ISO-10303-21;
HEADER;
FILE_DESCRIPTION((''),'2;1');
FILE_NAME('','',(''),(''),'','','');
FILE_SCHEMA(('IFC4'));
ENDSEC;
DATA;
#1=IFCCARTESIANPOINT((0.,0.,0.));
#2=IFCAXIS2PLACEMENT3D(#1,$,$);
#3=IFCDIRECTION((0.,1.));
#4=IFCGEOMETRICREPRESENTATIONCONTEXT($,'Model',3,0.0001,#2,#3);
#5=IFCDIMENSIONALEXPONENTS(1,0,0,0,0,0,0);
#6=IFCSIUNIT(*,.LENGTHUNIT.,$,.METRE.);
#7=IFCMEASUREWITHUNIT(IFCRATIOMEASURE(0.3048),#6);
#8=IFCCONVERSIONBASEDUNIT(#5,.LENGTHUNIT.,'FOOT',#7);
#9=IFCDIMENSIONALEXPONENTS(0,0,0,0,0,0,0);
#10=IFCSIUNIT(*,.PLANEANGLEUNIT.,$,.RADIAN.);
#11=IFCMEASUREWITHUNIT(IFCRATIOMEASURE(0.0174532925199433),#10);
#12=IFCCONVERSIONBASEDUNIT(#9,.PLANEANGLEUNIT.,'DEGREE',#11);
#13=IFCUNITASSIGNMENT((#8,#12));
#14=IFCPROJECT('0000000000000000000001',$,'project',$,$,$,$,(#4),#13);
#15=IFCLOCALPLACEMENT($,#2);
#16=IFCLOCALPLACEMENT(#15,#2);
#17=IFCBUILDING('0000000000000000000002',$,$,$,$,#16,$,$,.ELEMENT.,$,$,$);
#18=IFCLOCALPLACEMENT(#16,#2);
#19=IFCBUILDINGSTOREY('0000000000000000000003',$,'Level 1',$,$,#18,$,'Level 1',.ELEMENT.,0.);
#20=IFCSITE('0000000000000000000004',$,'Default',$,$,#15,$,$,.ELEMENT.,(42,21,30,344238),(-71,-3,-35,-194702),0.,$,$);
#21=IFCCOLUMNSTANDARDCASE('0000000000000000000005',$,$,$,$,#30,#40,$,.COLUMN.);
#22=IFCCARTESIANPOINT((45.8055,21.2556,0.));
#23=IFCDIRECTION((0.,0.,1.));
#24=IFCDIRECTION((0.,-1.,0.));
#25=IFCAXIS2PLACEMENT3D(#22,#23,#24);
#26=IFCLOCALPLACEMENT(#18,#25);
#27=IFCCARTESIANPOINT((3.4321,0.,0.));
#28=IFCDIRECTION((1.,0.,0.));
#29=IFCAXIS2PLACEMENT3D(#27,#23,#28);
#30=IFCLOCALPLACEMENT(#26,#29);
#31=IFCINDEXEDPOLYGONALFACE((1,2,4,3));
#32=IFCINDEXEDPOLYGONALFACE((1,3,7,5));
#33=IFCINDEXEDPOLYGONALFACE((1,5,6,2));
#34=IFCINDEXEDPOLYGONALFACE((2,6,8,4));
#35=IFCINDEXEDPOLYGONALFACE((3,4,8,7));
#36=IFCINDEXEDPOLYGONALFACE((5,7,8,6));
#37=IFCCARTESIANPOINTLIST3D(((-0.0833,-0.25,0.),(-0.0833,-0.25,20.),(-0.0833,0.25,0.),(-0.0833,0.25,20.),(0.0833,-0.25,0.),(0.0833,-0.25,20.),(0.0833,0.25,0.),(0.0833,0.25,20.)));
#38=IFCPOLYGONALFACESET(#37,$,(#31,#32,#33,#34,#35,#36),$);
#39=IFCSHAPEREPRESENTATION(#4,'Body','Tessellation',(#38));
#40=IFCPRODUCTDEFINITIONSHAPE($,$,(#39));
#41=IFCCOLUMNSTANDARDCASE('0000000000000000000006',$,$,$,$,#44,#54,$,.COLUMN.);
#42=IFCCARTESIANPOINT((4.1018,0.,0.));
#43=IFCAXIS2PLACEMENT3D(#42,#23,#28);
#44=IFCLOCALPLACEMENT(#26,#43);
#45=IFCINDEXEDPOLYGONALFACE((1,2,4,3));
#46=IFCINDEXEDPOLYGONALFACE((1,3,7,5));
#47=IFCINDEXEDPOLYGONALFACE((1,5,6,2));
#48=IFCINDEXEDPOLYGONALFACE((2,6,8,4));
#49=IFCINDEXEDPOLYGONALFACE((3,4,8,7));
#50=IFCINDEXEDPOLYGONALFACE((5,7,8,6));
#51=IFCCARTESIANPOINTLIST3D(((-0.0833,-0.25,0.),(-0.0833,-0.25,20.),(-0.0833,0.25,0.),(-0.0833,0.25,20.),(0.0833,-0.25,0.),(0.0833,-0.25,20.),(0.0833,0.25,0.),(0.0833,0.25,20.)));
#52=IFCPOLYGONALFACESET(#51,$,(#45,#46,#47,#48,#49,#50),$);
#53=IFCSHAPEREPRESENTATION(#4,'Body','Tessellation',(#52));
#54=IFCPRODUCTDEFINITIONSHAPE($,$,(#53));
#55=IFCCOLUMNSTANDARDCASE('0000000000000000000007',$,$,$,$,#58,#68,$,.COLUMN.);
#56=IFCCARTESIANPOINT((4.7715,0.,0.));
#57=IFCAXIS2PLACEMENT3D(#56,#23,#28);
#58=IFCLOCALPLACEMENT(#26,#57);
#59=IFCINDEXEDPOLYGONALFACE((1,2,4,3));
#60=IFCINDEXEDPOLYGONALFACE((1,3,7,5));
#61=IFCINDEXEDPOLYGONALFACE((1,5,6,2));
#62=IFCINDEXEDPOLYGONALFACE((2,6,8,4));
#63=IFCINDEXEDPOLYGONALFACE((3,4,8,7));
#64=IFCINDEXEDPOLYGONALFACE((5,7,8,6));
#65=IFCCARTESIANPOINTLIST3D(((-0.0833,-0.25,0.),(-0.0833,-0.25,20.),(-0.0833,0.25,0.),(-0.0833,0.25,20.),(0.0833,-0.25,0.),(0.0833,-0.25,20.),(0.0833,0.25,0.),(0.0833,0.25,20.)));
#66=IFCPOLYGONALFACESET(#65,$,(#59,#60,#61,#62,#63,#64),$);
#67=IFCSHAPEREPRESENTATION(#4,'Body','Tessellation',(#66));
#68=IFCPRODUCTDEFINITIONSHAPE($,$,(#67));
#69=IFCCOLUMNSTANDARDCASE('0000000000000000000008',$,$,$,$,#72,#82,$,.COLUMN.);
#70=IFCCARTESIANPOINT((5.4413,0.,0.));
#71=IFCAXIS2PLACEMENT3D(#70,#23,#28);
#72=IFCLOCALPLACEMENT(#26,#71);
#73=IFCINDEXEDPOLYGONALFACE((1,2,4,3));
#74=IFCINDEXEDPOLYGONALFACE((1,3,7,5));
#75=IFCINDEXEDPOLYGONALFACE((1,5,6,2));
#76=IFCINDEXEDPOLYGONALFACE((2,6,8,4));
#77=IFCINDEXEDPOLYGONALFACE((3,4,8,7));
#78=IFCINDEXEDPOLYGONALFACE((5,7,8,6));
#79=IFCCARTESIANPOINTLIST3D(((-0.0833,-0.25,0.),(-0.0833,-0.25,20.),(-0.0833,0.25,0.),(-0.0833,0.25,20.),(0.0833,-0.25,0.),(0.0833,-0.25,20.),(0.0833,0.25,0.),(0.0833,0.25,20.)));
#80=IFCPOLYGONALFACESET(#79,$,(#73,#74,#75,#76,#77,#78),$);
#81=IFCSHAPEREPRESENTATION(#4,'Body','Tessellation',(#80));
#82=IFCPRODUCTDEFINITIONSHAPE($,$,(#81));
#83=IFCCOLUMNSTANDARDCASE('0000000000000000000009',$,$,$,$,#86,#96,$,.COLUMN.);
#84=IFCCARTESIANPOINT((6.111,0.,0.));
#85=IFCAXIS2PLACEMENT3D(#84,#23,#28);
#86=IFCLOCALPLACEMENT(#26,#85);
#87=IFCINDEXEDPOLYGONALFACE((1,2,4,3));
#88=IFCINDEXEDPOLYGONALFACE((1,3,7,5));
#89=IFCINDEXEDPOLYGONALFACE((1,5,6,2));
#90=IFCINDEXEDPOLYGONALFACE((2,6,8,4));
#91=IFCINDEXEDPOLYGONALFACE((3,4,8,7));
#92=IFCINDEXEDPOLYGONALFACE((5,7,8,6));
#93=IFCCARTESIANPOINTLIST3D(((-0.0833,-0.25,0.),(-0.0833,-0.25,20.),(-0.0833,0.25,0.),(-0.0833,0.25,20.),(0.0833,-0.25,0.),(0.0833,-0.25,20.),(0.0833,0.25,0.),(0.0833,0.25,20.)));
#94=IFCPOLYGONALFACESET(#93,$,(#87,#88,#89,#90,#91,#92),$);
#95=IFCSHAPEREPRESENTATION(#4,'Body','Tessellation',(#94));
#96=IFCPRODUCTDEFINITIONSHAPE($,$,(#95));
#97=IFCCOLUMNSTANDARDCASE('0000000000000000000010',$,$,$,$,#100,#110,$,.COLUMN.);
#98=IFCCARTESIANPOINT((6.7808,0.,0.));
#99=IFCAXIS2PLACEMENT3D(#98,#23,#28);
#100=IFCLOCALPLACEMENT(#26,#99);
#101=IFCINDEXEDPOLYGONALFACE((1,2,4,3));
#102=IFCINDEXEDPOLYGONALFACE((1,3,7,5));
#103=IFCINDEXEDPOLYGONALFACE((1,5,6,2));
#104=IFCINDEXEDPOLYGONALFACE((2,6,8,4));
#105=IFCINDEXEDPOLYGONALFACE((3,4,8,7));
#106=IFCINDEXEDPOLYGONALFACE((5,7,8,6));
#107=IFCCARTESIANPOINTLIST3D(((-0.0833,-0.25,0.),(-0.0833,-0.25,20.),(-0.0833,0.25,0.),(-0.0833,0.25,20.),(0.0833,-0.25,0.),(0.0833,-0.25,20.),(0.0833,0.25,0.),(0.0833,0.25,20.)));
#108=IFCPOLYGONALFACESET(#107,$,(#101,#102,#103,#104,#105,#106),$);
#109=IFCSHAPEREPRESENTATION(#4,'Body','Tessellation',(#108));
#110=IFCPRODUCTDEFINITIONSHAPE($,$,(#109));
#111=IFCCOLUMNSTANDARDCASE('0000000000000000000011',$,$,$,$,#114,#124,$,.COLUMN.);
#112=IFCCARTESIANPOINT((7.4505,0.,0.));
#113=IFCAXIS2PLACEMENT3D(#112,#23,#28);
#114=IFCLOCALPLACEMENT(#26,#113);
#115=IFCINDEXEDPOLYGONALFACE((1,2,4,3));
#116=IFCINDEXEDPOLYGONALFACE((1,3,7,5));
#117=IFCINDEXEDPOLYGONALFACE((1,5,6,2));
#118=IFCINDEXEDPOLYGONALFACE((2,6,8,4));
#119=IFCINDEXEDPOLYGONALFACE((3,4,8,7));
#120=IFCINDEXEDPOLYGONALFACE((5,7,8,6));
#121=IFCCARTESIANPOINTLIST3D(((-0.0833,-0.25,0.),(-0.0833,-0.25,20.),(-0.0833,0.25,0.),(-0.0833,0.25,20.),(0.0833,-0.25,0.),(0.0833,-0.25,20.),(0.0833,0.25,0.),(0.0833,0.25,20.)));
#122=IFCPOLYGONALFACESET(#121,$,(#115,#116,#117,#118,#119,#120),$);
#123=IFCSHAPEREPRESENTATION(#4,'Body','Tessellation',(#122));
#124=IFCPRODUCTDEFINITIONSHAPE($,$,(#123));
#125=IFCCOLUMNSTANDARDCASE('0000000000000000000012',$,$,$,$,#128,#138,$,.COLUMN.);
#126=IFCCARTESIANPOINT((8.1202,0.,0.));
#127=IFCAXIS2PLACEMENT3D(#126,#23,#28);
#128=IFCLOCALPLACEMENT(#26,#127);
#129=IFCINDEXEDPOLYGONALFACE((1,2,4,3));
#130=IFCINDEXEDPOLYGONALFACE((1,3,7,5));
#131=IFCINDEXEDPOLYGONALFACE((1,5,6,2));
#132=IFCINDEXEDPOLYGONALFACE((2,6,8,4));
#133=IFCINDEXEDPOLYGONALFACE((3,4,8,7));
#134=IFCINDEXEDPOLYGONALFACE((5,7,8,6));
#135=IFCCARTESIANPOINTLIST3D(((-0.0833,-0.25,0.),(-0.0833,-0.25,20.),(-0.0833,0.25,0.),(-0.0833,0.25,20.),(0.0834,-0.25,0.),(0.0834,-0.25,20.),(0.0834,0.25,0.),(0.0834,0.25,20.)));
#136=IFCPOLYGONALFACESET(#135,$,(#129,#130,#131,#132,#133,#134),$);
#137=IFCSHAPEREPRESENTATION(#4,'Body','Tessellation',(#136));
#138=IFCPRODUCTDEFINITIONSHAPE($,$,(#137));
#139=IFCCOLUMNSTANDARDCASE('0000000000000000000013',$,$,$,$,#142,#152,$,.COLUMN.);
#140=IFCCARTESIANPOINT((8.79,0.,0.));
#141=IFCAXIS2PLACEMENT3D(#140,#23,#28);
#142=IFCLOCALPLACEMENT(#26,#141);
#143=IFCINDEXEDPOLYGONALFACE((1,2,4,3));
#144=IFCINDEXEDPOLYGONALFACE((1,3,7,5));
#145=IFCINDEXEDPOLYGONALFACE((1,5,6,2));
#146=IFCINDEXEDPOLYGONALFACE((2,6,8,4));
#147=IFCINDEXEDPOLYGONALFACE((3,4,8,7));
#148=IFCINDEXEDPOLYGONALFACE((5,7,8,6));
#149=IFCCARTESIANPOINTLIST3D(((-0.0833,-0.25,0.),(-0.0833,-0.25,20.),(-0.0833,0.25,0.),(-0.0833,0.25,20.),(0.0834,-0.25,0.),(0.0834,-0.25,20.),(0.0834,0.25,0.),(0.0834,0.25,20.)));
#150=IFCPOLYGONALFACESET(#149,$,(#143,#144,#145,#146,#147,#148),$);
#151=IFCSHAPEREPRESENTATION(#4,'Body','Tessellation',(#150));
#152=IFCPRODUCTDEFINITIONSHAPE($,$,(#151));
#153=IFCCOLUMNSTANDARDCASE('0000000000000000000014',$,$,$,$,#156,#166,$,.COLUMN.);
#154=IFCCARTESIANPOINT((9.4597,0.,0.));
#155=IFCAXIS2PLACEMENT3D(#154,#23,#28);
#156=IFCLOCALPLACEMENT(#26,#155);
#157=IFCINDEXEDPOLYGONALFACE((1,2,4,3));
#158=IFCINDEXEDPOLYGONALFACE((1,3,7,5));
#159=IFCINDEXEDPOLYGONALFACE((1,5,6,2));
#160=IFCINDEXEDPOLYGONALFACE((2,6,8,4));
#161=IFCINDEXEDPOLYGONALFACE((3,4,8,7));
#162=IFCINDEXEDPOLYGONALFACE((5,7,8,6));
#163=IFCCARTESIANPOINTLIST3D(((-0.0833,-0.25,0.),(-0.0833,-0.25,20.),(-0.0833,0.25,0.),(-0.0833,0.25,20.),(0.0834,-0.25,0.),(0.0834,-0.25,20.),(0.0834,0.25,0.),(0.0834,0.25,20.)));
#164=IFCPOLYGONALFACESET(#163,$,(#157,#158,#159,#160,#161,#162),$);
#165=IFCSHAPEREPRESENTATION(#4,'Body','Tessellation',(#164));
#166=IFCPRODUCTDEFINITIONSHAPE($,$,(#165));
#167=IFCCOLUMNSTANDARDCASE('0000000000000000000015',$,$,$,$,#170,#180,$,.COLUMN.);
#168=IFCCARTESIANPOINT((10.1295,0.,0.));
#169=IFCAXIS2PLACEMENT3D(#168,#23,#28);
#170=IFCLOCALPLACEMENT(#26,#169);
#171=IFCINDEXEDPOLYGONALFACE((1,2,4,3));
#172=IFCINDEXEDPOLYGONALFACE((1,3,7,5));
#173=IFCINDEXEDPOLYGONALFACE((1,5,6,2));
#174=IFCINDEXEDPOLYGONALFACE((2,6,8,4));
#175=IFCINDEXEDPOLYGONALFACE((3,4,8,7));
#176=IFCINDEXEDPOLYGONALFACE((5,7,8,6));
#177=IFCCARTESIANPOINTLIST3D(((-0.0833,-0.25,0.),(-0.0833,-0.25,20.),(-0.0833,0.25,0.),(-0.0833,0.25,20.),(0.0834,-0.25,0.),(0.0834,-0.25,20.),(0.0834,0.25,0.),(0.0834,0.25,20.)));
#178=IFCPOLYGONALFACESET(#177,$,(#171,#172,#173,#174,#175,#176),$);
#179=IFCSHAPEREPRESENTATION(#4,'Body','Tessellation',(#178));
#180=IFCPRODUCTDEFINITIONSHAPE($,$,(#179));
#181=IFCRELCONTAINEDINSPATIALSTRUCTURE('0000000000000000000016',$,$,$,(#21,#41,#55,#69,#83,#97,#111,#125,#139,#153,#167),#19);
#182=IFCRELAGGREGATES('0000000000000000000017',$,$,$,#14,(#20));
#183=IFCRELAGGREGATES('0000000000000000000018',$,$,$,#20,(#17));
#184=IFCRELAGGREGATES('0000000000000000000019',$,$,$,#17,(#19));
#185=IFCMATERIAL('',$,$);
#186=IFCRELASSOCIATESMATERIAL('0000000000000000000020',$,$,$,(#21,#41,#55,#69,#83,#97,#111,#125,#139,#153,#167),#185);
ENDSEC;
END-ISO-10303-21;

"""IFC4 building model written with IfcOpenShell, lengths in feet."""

from ifc_helpers import new_model, entity, si_unit, converted_unit, direction, frame, origin, place, context, project, spatial, rectangle, extrude, material, element, save


model = new_model("IFC4")

# Units and contexts
model_context = context("Model", 3, precision=0.0001, world=origin(), true_north=direction((0.0, 1.0)))
ifc_project = project(units=[converted_unit("LENGTHUNIT", "FOOT", entity("IfcRatioMeasure", 0.3048), si_unit("LENGTHUNIT", "METRE"), dimensions=[1, 0, 0, 0, 0, 0, 0]), converted_unit("PLANEANGLEUNIT", "DEGREE", entity("IfcRatioMeasure", 0.0174532925199433), si_unit("PLANEANGLEUNIT", "RADIAN"), dimensions=[0, 0, 0, 0, 0, 0, 0])], contexts=[model_context])

# Site, building, storey
site_placement = place(None, origin())
site = spatial("IfcSite", under=ifc_project, at=site_placement, Name="Default", CompositionType="ELEMENT", RefLatitude=(42, 21, 30, 344238), RefLongitude=(-71, -3, -35, -194702), RefElevation=0.0)
building_placement = place(site_placement, origin())
building = spatial("IfcBuilding", under=site, at=building_placement, CompositionType="ELEMENT")
storey_placement = place(building_placement, origin())
storey = spatial("IfcBuildingStorey", under=building, at=storey_placement, Name="Level 1", LongName="Level 1", CompositionType="ELEMENT", Elevation=0.0)

# Columns
ifc_material_1 = material(Name="")
wall_1_placement = place(storey_placement, frame((45.8055, 21.2556, 0.0), z_axis=(0.0, 0.0, 1.0), x_axis=(0.0, -1.0, 0.0)))
for number, where, z_axis, x_axis in (
    (1, (3.4321, 0.0, 0.0), (0.0, 0.0, 1.0), (1.0, 0.0, 0.0)),
    (2, (4.1018, 0.0, 0.0), (0.0, 0.0, 1.0), (1.0, 0.0, 0.0)),
    (3, (4.7715, 0.0, 0.0), (0.0, 0.0, 1.0), (1.0, 0.0, 0.0)),
    (4, (5.4413, 0.0, 0.0), (0.0, 0.0, 1.0), (1.0, 0.0, 0.0)),
    (5, (6.111, 0.0, 0.0), (0.0, 0.0, 1.0), (1.0, 0.0, 0.0)),
    (6, (6.7808, 0.0, 0.0), (0.0, 0.0, 1.0), (1.0, 0.0, 0.0)),
    (7, (7.4505, 0.0, 0.0), (0.0, 0.0, 1.0), (1.0, 0.0, 0.0)),
    (8, (8.1202, 0.0, 0.0), (0.0, 0.0, 1.0), (1.0, 0.0, 0.0)),
    (9, (8.79, 0.0, 0.0), (0.0, 0.0, 1.0), (1.0, 0.0, 0.0)),
    (10, (9.4597, 0.0, 0.0), (0.0, 0.0, 1.0), (1.0, 0.0, 0.0)),
    (11, (10.1295, 0.0, 0.0), (0.0, 0.0, 1.0), (1.0, 0.0, 0.0)),
):
    element("IfcColumnStandardCase", number, at=place(wall_1_placement, frame(where, z_axis=z_axis, x_axis=x_axis)), inside=storey, material=ifc_material_1, PredefinedType="COLUMN", context=model_context, shape_type="SweptSolid", body=[
        extrude(rectangle(XDim=0.1667, YDim=0.5), origin(), (0.0, 0.0, 1.0), 20.0),
    ])

save(model, "model.ifc")
